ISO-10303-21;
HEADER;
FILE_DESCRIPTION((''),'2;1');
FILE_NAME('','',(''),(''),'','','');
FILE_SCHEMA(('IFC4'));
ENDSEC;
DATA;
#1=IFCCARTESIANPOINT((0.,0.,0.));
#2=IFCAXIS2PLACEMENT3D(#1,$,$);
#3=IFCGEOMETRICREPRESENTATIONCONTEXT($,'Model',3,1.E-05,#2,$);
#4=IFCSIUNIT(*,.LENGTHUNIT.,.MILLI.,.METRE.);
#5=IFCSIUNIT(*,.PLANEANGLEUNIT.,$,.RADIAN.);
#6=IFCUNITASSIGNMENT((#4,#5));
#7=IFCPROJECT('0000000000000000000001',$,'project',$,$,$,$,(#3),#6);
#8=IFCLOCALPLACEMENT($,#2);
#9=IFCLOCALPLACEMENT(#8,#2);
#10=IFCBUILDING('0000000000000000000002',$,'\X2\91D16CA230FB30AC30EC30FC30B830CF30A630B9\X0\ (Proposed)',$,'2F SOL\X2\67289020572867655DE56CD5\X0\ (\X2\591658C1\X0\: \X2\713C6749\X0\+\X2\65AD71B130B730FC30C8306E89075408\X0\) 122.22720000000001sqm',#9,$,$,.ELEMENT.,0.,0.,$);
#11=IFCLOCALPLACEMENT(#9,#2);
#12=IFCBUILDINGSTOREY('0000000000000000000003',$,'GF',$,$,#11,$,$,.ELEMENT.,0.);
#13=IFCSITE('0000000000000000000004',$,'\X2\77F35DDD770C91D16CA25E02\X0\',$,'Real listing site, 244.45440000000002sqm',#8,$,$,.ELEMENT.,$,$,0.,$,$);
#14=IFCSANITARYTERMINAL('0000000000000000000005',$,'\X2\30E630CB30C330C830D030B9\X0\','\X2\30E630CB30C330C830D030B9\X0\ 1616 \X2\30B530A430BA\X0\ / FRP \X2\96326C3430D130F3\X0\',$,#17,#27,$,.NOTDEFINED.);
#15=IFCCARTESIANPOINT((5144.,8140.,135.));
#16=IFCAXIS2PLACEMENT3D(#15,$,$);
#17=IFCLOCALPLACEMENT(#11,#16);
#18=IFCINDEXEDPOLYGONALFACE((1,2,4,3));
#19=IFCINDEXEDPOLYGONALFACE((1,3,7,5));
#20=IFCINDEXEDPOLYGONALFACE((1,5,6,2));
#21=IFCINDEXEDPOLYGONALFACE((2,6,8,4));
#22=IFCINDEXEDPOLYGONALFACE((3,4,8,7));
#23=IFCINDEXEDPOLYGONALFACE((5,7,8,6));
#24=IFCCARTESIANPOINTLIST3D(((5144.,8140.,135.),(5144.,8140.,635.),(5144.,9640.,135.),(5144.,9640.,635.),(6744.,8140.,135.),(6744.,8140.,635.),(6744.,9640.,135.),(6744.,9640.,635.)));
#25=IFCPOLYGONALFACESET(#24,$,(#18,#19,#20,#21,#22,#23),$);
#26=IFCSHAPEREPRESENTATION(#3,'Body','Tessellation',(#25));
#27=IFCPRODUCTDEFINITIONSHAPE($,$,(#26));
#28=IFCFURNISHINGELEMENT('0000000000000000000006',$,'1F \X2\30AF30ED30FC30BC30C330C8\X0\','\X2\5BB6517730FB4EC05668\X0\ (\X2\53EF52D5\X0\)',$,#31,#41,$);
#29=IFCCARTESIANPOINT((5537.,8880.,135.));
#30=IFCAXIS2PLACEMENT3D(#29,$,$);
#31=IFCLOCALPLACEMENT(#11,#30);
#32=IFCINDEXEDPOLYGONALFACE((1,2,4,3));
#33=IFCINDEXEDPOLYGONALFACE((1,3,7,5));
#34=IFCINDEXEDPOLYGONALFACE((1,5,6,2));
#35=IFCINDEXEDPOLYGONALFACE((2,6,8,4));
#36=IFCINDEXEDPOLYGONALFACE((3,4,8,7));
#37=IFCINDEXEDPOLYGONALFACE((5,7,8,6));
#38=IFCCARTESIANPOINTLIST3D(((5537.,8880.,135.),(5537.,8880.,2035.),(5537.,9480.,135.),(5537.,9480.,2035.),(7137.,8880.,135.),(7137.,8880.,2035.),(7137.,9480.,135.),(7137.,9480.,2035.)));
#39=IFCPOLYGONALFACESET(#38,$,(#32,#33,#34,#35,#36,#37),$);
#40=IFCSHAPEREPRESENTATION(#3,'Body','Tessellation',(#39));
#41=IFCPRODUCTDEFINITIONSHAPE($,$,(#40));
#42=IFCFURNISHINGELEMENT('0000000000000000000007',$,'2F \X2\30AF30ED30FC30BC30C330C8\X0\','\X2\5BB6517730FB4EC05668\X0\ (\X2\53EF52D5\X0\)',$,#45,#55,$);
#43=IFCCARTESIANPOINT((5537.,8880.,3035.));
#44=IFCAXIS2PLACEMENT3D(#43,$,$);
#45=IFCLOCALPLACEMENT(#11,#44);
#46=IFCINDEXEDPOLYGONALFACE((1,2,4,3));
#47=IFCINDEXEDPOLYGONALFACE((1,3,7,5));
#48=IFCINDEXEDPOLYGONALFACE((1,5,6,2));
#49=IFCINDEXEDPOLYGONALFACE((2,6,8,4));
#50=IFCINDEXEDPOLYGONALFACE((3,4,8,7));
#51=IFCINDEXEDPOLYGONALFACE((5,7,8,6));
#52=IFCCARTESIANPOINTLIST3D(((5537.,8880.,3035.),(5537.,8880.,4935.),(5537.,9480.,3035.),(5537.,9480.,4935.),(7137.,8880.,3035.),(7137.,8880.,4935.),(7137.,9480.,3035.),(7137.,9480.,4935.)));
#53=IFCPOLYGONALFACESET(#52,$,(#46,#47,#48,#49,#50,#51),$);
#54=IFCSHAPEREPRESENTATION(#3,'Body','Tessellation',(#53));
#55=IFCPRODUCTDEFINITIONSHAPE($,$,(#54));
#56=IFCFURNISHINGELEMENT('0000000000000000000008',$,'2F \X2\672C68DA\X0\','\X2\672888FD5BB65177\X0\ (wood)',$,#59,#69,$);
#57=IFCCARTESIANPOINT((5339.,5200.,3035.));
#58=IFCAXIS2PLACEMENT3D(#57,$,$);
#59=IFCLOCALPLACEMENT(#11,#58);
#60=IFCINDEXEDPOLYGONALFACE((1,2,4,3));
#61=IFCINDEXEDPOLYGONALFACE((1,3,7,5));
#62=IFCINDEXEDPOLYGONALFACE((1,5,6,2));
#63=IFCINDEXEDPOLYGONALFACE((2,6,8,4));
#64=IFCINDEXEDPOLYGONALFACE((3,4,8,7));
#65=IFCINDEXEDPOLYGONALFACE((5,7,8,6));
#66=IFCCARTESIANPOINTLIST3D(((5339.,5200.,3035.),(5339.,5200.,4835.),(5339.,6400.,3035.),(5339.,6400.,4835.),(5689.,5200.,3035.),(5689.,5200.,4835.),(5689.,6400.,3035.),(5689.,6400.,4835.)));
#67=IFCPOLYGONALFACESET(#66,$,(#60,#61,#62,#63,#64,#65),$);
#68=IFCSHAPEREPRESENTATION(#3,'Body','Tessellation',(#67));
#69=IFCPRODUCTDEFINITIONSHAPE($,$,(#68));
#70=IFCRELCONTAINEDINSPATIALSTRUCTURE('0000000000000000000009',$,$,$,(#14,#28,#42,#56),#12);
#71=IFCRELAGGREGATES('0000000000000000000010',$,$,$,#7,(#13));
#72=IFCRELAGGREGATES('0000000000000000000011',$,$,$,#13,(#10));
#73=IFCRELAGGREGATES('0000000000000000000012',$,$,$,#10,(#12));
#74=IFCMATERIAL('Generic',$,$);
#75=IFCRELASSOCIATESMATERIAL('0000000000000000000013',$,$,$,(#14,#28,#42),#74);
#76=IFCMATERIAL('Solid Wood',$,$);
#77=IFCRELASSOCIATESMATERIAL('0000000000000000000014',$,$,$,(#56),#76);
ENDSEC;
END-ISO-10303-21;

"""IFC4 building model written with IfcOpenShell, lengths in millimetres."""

from ifc_helpers import new_model, si_unit, frame, frame_2d, origin, place, context, project, spatial, rectangle, extrude, material, element, save


model = new_model("IFC4")

# Units and contexts
model_context = context("Model", 3, precision=1e-05, world=origin())
ifc_project = project(units=[si_unit("LENGTHUNIT", "METRE", prefix="MILLI"), si_unit("PLANEANGLEUNIT", "RADIAN")], contexts=[model_context])

# Site, building, storey
site_placement = place(None, origin())
site = spatial("IfcSite", under=ifc_project, at=site_placement, Name="石川県金沢市", ObjectType="Real listing site, 244.45440000000002sqm", CompositionType="ELEMENT", RefElevation=0.0)
building_placement = place(site_placement, origin())
building = spatial("IfcBuilding", under=site, at=building_placement, Name="金沢・ガレージハウス (Proposed)", ObjectType="2F SOL木造在来工法 (外壁: 焼杉+断熱シートの複合) 122.22720000000001sqm", CompositionType="ELEMENT", ElevationOfRefHeight=0.0, ElevationOfTerrain=0.0)
storey_placement = place(building_placement, origin())
storey = spatial("IfcBuildingStorey", under=building, at=storey_placement, Name="GF", CompositionType="ELEMENT", Elevation=0.0)

# Shared definitions
ifc_material_1 = material(Name="Solid Wood")

# Shared definitions
ifc_material_2 = material(Name="Generic")

# Sanitary terminal
sanitary_terminal_placement = place(storey_placement, frame((5144.0, 8140.0, 135.0)))
element("IfcSanitaryTerminal", 1, at=sanitary_terminal_placement, inside=storey, material=ifc_material_2, Name="ユニットバス", Description="ユニットバス 1616 サイズ / FRP 防水パン", PredefinedType="NOTDEFINED", context=model_context, shape_type="SweptSolid", body=[
    extrude(rectangle(XDim=1600.0, YDim=1500.0, at=frame_2d((800.0, 750.0))), frame((5144.0, 8140.0, 135.0)), (0.0, 0.0, 1.0), 500.0),
])

# Furnishing elements
furnishing_1_placement = place(storey_placement, frame((5537.0, 8880.0, 135.0)))
element("IfcFurnishingElement", 2, at=furnishing_1_placement, inside=storey, material=ifc_material_2, Name="1F クローゼット", Description="家具・什器 (可動)", context=model_context, shape_type="SweptSolid", body=[
    extrude(rectangle(XDim=1600.0, YDim=600.0, at=frame_2d((800.0, 300.0))), frame((5537.0, 8880.0, 135.0)), (0.0, 0.0, 1.0), 1900.0),
])
furnishing_2_placement = place(storey_placement, frame((5537.0, 8880.0, 3035.0)))
element("IfcFurnishingElement", 3, at=furnishing_2_placement, inside=storey, material=ifc_material_2, Name="2F クローゼット", Description="家具・什器 (可動)", context=model_context, shape_type="SweptSolid", body=[
    extrude(rectangle(XDim=1600.0, YDim=600.0, at=frame_2d((800.0, 300.0))), frame((5537.0, 8880.0, 3035.0)), (0.0, 0.0, 1.0), 1900.0),
])
furnishing_3_placement = place(storey_placement, frame((5339.0, 5200.0, 3035.0)))
element("IfcFurnishingElement", 4, at=furnishing_3_placement, inside=storey, material=ifc_material_1, Name="2F 本棚", Description="木製家具 (wood)", context=model_context, shape_type="SweptSolid", body=[
    extrude(rectangle(XDim=350.0, YDim=1200.0, at=frame_2d((175.0, 600.0))), frame((5339.0, 5200.0, 3035.0)), (0.0, 0.0, 1.0), 1800.0),
])

save(model, "model.ifc")
